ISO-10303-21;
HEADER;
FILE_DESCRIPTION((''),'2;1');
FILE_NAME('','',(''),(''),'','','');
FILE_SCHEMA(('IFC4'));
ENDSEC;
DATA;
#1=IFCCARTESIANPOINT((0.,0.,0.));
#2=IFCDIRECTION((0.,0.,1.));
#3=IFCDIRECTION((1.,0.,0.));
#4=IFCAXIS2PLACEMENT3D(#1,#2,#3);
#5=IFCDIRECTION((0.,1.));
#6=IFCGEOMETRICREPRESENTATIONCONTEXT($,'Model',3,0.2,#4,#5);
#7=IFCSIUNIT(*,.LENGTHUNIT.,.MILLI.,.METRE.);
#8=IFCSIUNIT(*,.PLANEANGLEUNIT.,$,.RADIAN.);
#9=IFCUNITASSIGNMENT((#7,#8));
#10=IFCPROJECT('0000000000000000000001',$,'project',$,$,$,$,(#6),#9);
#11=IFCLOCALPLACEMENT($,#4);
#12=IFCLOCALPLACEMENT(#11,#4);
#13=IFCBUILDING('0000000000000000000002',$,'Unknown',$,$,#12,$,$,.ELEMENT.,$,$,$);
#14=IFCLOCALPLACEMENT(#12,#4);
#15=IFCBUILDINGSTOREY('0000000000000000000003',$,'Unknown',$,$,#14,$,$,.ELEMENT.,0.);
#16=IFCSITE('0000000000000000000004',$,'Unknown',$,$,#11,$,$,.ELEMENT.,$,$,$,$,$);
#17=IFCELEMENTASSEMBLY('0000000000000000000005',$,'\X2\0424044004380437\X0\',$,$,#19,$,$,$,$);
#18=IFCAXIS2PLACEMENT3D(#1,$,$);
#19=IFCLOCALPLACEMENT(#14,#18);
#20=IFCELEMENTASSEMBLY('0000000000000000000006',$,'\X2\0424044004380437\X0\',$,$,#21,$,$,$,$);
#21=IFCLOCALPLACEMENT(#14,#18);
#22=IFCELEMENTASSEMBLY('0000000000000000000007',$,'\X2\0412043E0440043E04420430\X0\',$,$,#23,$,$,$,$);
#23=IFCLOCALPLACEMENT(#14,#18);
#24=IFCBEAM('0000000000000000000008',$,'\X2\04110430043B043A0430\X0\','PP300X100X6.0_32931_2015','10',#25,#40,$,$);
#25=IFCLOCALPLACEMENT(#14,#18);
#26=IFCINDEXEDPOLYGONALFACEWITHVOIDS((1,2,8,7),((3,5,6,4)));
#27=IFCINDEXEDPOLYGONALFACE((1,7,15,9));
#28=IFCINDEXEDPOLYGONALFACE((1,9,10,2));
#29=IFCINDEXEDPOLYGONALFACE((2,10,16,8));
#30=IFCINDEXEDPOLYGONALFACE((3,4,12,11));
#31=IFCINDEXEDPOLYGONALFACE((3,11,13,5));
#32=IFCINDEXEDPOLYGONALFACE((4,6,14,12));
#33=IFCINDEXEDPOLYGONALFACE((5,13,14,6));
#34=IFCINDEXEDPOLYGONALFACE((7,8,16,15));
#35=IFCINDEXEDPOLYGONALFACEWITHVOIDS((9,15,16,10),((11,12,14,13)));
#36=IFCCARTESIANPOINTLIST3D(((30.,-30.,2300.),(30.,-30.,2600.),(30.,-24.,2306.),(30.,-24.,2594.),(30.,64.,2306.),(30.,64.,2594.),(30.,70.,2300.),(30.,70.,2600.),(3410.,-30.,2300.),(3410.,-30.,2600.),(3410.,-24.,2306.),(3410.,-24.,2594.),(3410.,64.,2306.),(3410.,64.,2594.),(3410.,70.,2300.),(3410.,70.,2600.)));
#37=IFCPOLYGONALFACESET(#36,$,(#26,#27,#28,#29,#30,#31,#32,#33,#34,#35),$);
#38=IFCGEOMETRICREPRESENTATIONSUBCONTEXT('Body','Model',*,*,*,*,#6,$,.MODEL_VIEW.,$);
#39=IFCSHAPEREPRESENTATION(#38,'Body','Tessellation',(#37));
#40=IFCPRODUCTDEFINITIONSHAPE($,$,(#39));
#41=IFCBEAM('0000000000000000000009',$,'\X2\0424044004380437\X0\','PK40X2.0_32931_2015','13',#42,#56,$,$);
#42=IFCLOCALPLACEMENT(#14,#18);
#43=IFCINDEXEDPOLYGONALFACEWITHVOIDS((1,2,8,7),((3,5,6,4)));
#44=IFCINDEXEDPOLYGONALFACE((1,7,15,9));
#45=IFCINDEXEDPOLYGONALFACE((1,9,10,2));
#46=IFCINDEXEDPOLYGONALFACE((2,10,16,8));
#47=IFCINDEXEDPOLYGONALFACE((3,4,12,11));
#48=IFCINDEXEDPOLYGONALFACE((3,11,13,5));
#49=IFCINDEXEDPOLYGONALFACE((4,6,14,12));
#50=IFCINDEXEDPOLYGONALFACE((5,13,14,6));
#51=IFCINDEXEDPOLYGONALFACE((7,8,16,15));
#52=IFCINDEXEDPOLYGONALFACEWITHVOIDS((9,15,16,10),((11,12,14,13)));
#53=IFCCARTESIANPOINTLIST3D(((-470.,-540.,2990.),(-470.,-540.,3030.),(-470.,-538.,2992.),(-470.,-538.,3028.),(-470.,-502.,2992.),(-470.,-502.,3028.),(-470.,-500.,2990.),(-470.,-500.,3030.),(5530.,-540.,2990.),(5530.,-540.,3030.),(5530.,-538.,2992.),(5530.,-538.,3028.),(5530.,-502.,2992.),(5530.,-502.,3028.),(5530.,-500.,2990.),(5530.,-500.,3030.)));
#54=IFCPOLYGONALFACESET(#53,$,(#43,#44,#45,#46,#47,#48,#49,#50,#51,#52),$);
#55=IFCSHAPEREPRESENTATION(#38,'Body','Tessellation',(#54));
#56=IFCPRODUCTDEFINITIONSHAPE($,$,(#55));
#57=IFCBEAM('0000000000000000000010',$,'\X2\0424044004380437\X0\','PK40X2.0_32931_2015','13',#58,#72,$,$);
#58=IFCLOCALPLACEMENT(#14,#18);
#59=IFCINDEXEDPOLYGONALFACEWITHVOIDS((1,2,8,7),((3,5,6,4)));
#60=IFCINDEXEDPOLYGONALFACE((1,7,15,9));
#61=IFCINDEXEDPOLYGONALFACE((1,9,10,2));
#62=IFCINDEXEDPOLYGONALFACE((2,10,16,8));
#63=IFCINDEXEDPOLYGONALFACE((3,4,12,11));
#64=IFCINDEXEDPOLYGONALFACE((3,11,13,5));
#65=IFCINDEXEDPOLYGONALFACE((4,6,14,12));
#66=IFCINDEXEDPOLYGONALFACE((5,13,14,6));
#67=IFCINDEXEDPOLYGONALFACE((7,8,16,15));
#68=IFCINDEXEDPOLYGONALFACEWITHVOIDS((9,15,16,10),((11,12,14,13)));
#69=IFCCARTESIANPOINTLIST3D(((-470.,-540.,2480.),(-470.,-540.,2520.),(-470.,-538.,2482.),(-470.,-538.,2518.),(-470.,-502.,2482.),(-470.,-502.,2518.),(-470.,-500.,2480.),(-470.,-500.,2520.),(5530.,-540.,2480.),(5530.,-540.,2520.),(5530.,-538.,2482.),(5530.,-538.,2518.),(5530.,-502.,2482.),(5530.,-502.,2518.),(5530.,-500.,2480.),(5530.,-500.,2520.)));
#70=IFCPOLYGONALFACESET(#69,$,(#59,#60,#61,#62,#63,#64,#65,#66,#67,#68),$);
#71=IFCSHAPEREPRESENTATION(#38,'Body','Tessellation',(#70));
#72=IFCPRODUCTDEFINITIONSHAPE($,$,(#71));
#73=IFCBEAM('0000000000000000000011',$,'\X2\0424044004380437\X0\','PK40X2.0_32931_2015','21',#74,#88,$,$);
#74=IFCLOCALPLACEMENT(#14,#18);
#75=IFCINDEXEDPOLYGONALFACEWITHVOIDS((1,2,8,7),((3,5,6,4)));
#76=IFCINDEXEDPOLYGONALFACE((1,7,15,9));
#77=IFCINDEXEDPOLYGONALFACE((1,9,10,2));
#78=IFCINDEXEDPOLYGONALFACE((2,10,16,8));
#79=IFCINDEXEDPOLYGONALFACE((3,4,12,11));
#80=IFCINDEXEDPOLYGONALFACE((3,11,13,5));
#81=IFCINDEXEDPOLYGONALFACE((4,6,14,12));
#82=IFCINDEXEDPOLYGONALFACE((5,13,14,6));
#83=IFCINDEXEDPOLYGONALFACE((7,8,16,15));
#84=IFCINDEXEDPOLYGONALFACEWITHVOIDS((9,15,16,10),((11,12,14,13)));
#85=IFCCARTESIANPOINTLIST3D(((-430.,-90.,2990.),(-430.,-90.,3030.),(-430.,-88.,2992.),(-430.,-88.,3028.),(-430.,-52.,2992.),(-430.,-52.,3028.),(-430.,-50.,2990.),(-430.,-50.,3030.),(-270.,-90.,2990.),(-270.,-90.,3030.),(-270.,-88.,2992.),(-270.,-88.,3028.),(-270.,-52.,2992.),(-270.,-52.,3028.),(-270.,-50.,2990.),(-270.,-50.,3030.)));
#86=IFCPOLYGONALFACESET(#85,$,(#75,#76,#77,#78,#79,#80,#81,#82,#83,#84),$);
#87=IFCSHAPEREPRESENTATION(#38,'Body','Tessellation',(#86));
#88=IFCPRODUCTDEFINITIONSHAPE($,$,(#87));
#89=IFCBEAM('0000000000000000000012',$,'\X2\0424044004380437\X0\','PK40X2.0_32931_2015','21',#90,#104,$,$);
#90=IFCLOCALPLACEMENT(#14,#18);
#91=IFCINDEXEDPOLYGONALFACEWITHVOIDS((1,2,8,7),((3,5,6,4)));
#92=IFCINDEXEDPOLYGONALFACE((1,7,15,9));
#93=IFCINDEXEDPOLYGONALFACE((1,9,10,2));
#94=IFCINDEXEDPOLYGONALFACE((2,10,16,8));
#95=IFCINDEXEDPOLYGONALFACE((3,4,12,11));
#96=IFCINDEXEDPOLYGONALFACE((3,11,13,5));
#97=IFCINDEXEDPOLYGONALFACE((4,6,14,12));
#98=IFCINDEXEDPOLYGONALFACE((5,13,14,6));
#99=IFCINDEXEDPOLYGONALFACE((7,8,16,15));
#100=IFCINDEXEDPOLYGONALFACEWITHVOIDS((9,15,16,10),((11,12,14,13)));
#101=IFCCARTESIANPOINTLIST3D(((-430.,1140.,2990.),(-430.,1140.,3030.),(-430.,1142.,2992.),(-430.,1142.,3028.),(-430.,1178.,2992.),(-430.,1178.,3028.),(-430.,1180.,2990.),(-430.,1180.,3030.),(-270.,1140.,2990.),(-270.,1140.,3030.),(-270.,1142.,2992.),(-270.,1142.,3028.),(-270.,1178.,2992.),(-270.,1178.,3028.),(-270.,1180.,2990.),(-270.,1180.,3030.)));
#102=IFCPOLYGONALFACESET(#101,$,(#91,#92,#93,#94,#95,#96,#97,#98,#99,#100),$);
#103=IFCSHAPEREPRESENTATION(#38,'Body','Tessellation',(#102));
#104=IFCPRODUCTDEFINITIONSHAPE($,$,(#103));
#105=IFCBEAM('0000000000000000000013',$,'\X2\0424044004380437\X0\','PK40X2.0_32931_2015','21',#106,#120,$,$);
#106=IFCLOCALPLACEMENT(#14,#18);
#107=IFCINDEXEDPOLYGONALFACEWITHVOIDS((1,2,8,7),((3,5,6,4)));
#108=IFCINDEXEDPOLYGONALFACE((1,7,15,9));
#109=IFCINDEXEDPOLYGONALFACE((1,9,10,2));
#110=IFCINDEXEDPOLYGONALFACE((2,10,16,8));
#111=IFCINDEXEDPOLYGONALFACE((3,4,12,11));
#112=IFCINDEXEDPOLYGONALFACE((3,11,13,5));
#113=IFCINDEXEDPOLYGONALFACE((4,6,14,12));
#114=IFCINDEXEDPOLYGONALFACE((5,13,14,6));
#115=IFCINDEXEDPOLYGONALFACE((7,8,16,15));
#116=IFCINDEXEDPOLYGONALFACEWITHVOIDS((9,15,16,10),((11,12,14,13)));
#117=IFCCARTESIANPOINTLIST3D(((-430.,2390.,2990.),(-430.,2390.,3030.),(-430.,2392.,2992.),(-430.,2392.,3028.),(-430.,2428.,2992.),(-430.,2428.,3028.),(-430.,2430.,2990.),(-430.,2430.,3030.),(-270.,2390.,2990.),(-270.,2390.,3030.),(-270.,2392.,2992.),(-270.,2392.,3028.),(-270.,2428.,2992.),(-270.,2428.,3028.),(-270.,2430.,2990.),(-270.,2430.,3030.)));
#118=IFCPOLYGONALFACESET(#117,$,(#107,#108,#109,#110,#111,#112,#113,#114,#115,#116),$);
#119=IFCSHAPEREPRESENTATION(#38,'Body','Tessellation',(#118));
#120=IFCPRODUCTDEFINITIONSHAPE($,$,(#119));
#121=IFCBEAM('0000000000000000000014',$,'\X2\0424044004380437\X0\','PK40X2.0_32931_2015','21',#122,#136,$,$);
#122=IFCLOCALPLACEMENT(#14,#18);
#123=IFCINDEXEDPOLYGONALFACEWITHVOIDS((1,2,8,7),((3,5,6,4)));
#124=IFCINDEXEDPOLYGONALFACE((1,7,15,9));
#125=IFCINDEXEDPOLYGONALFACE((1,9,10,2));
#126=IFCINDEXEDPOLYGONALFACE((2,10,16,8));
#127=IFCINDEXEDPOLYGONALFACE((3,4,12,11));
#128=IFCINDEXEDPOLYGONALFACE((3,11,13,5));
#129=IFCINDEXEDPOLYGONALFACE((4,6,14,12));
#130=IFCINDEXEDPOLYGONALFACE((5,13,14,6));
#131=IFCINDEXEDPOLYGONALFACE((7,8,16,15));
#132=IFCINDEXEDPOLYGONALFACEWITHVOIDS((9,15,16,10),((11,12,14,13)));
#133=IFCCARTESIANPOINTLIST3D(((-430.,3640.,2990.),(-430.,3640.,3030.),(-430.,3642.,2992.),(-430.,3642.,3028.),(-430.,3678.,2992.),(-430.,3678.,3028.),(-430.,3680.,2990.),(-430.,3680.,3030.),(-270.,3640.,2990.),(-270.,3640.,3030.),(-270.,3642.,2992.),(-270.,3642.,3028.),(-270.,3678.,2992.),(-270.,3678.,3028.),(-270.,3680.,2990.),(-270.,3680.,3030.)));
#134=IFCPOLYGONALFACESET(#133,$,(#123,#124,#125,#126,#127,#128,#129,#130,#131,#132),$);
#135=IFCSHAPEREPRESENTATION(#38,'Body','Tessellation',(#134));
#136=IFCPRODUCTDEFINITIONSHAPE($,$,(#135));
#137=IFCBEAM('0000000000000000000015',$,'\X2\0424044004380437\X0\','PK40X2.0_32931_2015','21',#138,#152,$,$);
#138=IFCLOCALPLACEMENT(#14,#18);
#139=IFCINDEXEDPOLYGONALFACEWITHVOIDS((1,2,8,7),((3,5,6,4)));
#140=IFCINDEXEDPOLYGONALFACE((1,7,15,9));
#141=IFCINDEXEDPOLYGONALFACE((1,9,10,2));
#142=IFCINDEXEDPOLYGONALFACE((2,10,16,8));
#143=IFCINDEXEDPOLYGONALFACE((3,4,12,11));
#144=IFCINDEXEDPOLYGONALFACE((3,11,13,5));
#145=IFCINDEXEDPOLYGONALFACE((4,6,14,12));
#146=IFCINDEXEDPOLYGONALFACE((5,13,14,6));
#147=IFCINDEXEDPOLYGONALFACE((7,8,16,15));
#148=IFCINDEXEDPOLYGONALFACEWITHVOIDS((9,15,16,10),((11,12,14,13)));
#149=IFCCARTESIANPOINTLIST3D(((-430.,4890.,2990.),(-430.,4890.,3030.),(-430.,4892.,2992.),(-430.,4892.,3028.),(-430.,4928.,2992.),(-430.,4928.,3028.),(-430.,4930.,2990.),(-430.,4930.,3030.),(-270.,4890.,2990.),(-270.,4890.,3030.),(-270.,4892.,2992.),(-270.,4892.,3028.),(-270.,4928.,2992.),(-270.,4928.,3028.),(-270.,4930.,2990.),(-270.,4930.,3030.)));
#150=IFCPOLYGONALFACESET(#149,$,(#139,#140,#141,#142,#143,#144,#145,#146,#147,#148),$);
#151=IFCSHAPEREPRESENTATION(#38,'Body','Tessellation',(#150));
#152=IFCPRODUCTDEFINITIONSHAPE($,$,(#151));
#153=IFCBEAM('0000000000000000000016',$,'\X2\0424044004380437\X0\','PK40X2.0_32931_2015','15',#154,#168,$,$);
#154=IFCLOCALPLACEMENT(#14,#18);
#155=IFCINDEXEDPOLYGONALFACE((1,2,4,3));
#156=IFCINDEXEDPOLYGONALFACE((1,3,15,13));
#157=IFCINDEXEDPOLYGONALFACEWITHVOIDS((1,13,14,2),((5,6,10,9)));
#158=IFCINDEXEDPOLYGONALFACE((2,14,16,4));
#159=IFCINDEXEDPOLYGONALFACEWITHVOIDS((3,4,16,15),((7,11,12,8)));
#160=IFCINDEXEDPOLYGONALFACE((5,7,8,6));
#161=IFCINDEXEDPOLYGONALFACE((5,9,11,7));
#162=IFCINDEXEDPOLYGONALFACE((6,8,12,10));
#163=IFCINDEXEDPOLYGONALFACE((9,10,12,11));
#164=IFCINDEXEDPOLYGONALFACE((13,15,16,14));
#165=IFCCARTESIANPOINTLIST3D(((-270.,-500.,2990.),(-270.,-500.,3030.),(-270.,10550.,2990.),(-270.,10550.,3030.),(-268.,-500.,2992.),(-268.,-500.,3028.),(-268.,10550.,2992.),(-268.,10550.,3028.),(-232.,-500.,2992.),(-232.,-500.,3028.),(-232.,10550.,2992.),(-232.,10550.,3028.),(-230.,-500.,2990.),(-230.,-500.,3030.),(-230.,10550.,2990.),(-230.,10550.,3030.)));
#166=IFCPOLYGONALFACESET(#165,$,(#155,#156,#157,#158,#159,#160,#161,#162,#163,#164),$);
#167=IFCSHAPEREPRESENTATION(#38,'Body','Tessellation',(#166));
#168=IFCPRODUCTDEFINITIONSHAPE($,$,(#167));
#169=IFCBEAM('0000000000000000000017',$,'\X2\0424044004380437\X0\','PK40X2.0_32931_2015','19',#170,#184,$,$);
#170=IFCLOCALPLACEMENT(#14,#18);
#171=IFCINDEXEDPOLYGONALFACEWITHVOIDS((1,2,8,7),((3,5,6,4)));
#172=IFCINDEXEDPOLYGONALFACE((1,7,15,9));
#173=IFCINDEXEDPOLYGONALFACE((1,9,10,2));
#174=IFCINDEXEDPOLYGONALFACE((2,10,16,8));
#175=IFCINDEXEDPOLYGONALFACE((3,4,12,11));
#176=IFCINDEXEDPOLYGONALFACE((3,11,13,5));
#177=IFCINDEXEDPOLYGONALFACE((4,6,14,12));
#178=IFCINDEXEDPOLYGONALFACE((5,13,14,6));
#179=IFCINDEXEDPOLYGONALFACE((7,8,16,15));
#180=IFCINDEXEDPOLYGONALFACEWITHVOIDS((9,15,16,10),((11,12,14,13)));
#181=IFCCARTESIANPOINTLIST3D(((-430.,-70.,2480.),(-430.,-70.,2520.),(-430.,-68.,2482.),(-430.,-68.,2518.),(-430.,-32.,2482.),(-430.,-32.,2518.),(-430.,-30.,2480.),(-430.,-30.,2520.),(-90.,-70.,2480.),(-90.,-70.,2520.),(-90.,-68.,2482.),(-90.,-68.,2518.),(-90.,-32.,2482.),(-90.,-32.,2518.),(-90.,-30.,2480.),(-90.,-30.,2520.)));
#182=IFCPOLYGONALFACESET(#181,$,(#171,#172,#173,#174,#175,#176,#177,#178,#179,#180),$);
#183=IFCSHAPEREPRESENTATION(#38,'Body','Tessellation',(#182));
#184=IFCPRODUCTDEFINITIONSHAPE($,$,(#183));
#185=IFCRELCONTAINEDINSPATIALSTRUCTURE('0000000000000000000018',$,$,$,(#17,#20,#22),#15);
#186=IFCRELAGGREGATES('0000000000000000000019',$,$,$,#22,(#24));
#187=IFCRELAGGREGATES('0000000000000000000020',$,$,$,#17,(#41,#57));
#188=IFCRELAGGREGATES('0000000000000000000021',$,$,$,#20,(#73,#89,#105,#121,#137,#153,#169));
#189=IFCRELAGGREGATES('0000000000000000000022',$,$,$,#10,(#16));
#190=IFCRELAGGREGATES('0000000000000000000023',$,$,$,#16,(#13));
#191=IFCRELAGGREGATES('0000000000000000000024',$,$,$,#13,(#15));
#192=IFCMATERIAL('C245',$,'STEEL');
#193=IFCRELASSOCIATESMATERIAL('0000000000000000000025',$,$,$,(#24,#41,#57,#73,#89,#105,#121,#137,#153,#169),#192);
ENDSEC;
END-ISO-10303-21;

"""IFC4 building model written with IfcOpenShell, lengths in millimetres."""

from ifc_helpers import new_model, si_unit, direction, frame, origin_with_axes, place, context, subcontext, project, spatial, line, indexed_curve, outline, extrude, material, element, aggregate, save


model = new_model("IFC4")

# Units and contexts
model_context = context("Model", 3, precision=0.2, world=origin_with_axes(), true_north=direction((0.0, 1.0)))
body_context = subcontext(model_context, "Body", "Model", "MODEL_VIEW")
ifc_project = project(units=[si_unit("LENGTHUNIT", "METRE", prefix="MILLI"), si_unit("PLANEANGLEUNIT", "RADIAN")], contexts=[model_context])

# Site, building, storey
site_placement = place(None, origin_with_axes())
site = spatial("IfcSite", under=ifc_project, at=site_placement, Name="Unknown", CompositionType="ELEMENT")
building_placement = place(site_placement, origin_with_axes())
building = spatial("IfcBuilding", under=site, at=building_placement, Name="Unknown", CompositionType="ELEMENT")
storey_placement = place(building_placement, origin_with_axes())
storey = spatial("IfcBuildingStorey", under=building, at=storey_placement, Name="Unknown", CompositionType="ELEMENT", Elevation=0.0)

# Shared definitions
ifc_material = material(Name="C245", Category="STEEL")

# Element assemblies
assembly_1_placement = place(storey_placement, frame((-470.0, -520.0, 3010.0), z_axis=(0.0, -1.0, 0.0), x_axis=(1.0, 0.0, 0.0)))
assembly_1 = element("IfcElementAssembly", 1, at=assembly_1_placement, inside=storey, Name="Фриз")
assembly_2_placement = place(storey_placement, frame((-450.0, -500.0, 3010.0), z_axis=(1.0, 0.0, 0.0), x_axis=(0.0, 1.0, 0.0)))
assembly_2 = element("IfcElementAssembly", 2, at=assembly_2_placement, inside=storey, Name="Фриз")

# Element assembly, beam
assembly_3_placement = place(storey_placement, frame((30.0, 20.0, 2450.0), z_axis=(0.0, -1.0, 0.0), x_axis=(1.0, 0.0, 0.0)))
assembly_3 = element("IfcElementAssembly", 3, at=assembly_3_placement, inside=storey, Name="Ворота")
beam_1_placement = place(assembly_3_placement, origin_with_axes())
beam_1 = element("IfcBeam", 4, at=beam_1_placement, material=ifc_material, Name="Балка", Description="PP300X100X6.0_32931_2015", ObjectType="10", context=body_context, shape_type="SolidModel", body=[
    extrude(outline(indexed_curve([(-50.0, -150.0), (50.0, -150.0), (50.0, 150.0), (-50.0, 150.0)], segments=[line(1, 2, 3, 4, 1)]), holes=[indexed_curve([(-44.0, -144.0), (-44.0, 144.0), (44.0, 144.0), (44.0, -144.0)], segments=[line(1, 2, 3, 4, 1)])]), frame((0.0, 0.0, 0.0), z_axis=(-1.0, 0.0, 0.0), x_axis=(0.0, 0.0, 1.0)), (0.0, 0.0, -1.0), 3380.0),
])
aggregate(assembly_3, [beam_1])

# Beams
beam_2_placement = place(assembly_1_placement, origin_with_axes())
beam_2 = element("IfcBeam", 5, at=beam_2_placement, material=ifc_material, Name="Фриз", Description="PK40X2.0_32931_2015", ObjectType="13", context=body_context, shape_type="SolidModel", body=[
    extrude(outline(indexed_curve([(-20.0, -20.0), (20.0, -20.0), (20.0, 20.0), (-20.0, 20.0)], segments=[line(1, 2, 3, 4, 1)]), holes=[indexed_curve([(-18.0, -18.0), (-18.0, 18.0), (18.0, 18.0), (18.0, -18.0)], segments=[line(1, 2, 3, 4, 1)])]), frame((0.0, 0.0, 0.0), z_axis=(-1.0, 0.0, 0.0), x_axis=(0.0, 0.0, 1.0)), (0.0, 0.0, -1.0), 6000.0),
])
beam_3_placement = place(assembly_1_placement, frame((0.0, -510.0, 0.0), z_axis=(0.0, 0.0, 1.0), x_axis=(1.0, 0.0, 0.0)))
beam_3 = element("IfcBeam", 6, at=beam_3_placement, material=ifc_material, Name="Фриз", Description="PK40X2.0_32931_2015", ObjectType="13", context=body_context, shape_type="SolidModel", body=[
    extrude(outline(indexed_curve([(-20.0, -20.0), (20.0, -20.0), (20.0, 20.0), (-20.0, 20.0)], segments=[line(1, 2, 3, 4, 1)]), holes=[indexed_curve([(-18.0, -18.0), (-18.0, 18.0), (18.0, 18.0), (18.0, -18.0)], segments=[line(1, 2, 3, 4, 1)])]), frame((0.0, 0.0, 0.0), z_axis=(-1.0, 0.0, 0.0), x_axis=(0.0, 0.0, 1.0)), (0.0, 0.0, -1.0), 6000.0),
])
aggregate(assembly_1, [beam_2, beam_3])
beam_4_placement = place(assembly_2_placement, frame((430.0, 0.0, 20.0), z_axis=(-1.0, 0.0, 0.0), x_axis=(0.0, 0.0, 1.0)))
beam_4 = element("IfcBeam", 7, at=beam_4_placement, material=ifc_material, Name="Фриз", Description="PK40X2.0_32931_2015", ObjectType="21", context=body_context, shape_type="SolidModel", body=[
    extrude(outline(indexed_curve([(-20.0, -20.0), (20.0, -20.0), (20.0, 20.0), (-20.0, 20.0)], segments=[line(1, 2, 3, 4, 1)]), holes=[indexed_curve([(-18.0, -18.0), (-18.0, 18.0), (18.0, 18.0), (18.0, -18.0)], segments=[line(1, 2, 3, 4, 1)])]), frame((0.0, 0.0, 0.0), z_axis=(-1.0, 0.0, 0.0), x_axis=(0.0, 0.0, 1.0)), (0.0, 0.0, -1.0), 160.0),
])
beam_5_placement = place(assembly_2_placement, frame((1660.0, 0.0, 20.0), z_axis=(-1.0, 0.0, 0.0), x_axis=(0.0, 0.0, 1.0)))
beam_5 = element("IfcBeam", 8, at=beam_5_placement, material=ifc_material, Name="Фриз", Description="PK40X2.0_32931_2015", ObjectType="21", context=body_context, shape_type="SolidModel", body=[
    extrude(outline(indexed_curve([(-20.0, -20.0), (20.0, -20.0), (20.0, 20.0), (-20.0, 20.0)], segments=[line(1, 2, 3, 4, 1)]), holes=[indexed_curve([(-18.0, -18.0), (-18.0, 18.0), (18.0, 18.0), (18.0, -18.0)], segments=[line(1, 2, 3, 4, 1)])]), frame((0.0, 0.0, 0.0), z_axis=(-1.0, 0.0, 0.0), x_axis=(0.0, 0.0, 1.0)), (0.0, 0.0, -1.0), 160.0),
])
beam_6_placement = place(assembly_2_placement, frame((2910.0, 0.0, 20.0), z_axis=(-1.0, 0.0, 0.0), x_axis=(0.0, 0.0, 1.0)))
beam_6 = element("IfcBeam", 9, at=beam_6_placement, material=ifc_material, Name="Фриз", Description="PK40X2.0_32931_2015", ObjectType="21", context=body_context, shape_type="SolidModel", body=[
    extrude(outline(indexed_curve([(-20.0, -20.0), (20.0, -20.0), (20.0, 20.0), (-20.0, 20.0)], segments=[line(1, 2, 3, 4, 1)]), holes=[indexed_curve([(-18.0, -18.0), (-18.0, 18.0), (18.0, 18.0), (18.0, -18.0)], segments=[line(1, 2, 3, 4, 1)])]), frame((0.0, 0.0, 0.0), z_axis=(-1.0, 0.0, 0.0), x_axis=(0.0, 0.0, 1.0)), (0.0, 0.0, -1.0), 160.0),
])
beam_7_placement = place(assembly_2_placement, frame((4160.0, 0.0, 20.0), z_axis=(-1.0, 0.0, 0.0), x_axis=(0.0, 0.0, 1.0)))
beam_7 = element("IfcBeam", 10, at=beam_7_placement, material=ifc_material, Name="Фриз", Description="PK40X2.0_32931_2015", ObjectType="21", context=body_context, shape_type="SolidModel", body=[
    extrude(outline(indexed_curve([(-20.0, -20.0), (20.0, -20.0), (20.0, 20.0), (-20.0, 20.0)], segments=[line(1, 2, 3, 4, 1)]), holes=[indexed_curve([(-18.0, -18.0), (-18.0, 18.0), (18.0, 18.0), (18.0, -18.0)], segments=[line(1, 2, 3, 4, 1)])]), frame((0.0, 0.0, 0.0), z_axis=(-1.0, 0.0, 0.0), x_axis=(0.0, 0.0, 1.0)), (0.0, 0.0, -1.0), 160.0),
])
beam_8_placement = place(assembly_2_placement, frame((5410.0, 0.0, 20.0), z_axis=(-1.0, 0.0, 0.0), x_axis=(0.0, 0.0, 1.0)))
beam_8 = element("IfcBeam", 11, at=beam_8_placement, material=ifc_material, Name="Фриз", Description="PK40X2.0_32931_2015", ObjectType="21", context=body_context, shape_type="SolidModel", body=[
    extrude(outline(indexed_curve([(-20.0, -20.0), (20.0, -20.0), (20.0, 20.0), (-20.0, 20.0)], segments=[line(1, 2, 3, 4, 1)]), holes=[indexed_curve([(-18.0, -18.0), (-18.0, 18.0), (18.0, 18.0), (18.0, -18.0)], segments=[line(1, 2, 3, 4, 1)])]), frame((0.0, 0.0, 0.0), z_axis=(-1.0, 0.0, 0.0), x_axis=(0.0, 0.0, 1.0)), (0.0, 0.0, -1.0), 160.0),
])
beam_9_placement = place(assembly_2_placement, frame((0.0, 0.0, 200.0), z_axis=(0.0, 0.0, 1.0), x_axis=(1.0, 0.0, 0.0)))
beam_9 = element("IfcBeam", 12, at=beam_9_placement, material=ifc_material, Name="Фриз", Description="PK40X2.0_32931_2015", ObjectType="15", context=body_context, shape_type="SolidModel", body=[
    extrude(outline(indexed_curve([(-20.0, -20.0), (20.0, -20.0), (20.0, 20.0), (-20.0, 20.0)], segments=[line(1, 2, 3, 4, 1)]), holes=[indexed_curve([(-18.0, -18.0), (-18.0, 18.0), (18.0, 18.0), (18.0, -18.0)], segments=[line(1, 2, 3, 4, 1)])]), frame((0.0, 0.0, 0.0), z_axis=(-1.0, 0.0, 0.0), x_axis=(0.0, 0.0, 1.0)), (0.0, 0.0, -1.0), 11050.0),
])
beam_10_placement = place(assembly_2_placement, frame((450.0, -510.0, 20.0), z_axis=(-1.0, 0.0, 0.0), x_axis=(0.0, 0.0, 1.0)))
beam_10 = element("IfcBeam", 13, at=beam_10_placement, material=ifc_material, Name="Фриз", Description="PK40X2.0_32931_2015", ObjectType="19", context=body_context, shape_type="SolidModel", body=[
    extrude(outline(indexed_curve([(-20.0, -20.0), (20.0, -20.0), (20.0, 20.0), (-20.0, 20.0)], segments=[line(1, 2, 3, 4, 1)]), holes=[indexed_curve([(-18.0, -18.0), (-18.0, 18.0), (18.0, 18.0), (18.0, -18.0)], segments=[line(1, 2, 3, 4, 1)])]), frame((0.0, 0.0, 0.0), z_axis=(-1.0, 0.0, 0.0), x_axis=(0.0, 0.0, 1.0)), (0.0, 0.0, -1.0), 340.0),
])
aggregate(assembly_2, [beam_4, beam_5, beam_6, beam_7, beam_8, beam_9, beam_10])

save(model, "model.ifc")
